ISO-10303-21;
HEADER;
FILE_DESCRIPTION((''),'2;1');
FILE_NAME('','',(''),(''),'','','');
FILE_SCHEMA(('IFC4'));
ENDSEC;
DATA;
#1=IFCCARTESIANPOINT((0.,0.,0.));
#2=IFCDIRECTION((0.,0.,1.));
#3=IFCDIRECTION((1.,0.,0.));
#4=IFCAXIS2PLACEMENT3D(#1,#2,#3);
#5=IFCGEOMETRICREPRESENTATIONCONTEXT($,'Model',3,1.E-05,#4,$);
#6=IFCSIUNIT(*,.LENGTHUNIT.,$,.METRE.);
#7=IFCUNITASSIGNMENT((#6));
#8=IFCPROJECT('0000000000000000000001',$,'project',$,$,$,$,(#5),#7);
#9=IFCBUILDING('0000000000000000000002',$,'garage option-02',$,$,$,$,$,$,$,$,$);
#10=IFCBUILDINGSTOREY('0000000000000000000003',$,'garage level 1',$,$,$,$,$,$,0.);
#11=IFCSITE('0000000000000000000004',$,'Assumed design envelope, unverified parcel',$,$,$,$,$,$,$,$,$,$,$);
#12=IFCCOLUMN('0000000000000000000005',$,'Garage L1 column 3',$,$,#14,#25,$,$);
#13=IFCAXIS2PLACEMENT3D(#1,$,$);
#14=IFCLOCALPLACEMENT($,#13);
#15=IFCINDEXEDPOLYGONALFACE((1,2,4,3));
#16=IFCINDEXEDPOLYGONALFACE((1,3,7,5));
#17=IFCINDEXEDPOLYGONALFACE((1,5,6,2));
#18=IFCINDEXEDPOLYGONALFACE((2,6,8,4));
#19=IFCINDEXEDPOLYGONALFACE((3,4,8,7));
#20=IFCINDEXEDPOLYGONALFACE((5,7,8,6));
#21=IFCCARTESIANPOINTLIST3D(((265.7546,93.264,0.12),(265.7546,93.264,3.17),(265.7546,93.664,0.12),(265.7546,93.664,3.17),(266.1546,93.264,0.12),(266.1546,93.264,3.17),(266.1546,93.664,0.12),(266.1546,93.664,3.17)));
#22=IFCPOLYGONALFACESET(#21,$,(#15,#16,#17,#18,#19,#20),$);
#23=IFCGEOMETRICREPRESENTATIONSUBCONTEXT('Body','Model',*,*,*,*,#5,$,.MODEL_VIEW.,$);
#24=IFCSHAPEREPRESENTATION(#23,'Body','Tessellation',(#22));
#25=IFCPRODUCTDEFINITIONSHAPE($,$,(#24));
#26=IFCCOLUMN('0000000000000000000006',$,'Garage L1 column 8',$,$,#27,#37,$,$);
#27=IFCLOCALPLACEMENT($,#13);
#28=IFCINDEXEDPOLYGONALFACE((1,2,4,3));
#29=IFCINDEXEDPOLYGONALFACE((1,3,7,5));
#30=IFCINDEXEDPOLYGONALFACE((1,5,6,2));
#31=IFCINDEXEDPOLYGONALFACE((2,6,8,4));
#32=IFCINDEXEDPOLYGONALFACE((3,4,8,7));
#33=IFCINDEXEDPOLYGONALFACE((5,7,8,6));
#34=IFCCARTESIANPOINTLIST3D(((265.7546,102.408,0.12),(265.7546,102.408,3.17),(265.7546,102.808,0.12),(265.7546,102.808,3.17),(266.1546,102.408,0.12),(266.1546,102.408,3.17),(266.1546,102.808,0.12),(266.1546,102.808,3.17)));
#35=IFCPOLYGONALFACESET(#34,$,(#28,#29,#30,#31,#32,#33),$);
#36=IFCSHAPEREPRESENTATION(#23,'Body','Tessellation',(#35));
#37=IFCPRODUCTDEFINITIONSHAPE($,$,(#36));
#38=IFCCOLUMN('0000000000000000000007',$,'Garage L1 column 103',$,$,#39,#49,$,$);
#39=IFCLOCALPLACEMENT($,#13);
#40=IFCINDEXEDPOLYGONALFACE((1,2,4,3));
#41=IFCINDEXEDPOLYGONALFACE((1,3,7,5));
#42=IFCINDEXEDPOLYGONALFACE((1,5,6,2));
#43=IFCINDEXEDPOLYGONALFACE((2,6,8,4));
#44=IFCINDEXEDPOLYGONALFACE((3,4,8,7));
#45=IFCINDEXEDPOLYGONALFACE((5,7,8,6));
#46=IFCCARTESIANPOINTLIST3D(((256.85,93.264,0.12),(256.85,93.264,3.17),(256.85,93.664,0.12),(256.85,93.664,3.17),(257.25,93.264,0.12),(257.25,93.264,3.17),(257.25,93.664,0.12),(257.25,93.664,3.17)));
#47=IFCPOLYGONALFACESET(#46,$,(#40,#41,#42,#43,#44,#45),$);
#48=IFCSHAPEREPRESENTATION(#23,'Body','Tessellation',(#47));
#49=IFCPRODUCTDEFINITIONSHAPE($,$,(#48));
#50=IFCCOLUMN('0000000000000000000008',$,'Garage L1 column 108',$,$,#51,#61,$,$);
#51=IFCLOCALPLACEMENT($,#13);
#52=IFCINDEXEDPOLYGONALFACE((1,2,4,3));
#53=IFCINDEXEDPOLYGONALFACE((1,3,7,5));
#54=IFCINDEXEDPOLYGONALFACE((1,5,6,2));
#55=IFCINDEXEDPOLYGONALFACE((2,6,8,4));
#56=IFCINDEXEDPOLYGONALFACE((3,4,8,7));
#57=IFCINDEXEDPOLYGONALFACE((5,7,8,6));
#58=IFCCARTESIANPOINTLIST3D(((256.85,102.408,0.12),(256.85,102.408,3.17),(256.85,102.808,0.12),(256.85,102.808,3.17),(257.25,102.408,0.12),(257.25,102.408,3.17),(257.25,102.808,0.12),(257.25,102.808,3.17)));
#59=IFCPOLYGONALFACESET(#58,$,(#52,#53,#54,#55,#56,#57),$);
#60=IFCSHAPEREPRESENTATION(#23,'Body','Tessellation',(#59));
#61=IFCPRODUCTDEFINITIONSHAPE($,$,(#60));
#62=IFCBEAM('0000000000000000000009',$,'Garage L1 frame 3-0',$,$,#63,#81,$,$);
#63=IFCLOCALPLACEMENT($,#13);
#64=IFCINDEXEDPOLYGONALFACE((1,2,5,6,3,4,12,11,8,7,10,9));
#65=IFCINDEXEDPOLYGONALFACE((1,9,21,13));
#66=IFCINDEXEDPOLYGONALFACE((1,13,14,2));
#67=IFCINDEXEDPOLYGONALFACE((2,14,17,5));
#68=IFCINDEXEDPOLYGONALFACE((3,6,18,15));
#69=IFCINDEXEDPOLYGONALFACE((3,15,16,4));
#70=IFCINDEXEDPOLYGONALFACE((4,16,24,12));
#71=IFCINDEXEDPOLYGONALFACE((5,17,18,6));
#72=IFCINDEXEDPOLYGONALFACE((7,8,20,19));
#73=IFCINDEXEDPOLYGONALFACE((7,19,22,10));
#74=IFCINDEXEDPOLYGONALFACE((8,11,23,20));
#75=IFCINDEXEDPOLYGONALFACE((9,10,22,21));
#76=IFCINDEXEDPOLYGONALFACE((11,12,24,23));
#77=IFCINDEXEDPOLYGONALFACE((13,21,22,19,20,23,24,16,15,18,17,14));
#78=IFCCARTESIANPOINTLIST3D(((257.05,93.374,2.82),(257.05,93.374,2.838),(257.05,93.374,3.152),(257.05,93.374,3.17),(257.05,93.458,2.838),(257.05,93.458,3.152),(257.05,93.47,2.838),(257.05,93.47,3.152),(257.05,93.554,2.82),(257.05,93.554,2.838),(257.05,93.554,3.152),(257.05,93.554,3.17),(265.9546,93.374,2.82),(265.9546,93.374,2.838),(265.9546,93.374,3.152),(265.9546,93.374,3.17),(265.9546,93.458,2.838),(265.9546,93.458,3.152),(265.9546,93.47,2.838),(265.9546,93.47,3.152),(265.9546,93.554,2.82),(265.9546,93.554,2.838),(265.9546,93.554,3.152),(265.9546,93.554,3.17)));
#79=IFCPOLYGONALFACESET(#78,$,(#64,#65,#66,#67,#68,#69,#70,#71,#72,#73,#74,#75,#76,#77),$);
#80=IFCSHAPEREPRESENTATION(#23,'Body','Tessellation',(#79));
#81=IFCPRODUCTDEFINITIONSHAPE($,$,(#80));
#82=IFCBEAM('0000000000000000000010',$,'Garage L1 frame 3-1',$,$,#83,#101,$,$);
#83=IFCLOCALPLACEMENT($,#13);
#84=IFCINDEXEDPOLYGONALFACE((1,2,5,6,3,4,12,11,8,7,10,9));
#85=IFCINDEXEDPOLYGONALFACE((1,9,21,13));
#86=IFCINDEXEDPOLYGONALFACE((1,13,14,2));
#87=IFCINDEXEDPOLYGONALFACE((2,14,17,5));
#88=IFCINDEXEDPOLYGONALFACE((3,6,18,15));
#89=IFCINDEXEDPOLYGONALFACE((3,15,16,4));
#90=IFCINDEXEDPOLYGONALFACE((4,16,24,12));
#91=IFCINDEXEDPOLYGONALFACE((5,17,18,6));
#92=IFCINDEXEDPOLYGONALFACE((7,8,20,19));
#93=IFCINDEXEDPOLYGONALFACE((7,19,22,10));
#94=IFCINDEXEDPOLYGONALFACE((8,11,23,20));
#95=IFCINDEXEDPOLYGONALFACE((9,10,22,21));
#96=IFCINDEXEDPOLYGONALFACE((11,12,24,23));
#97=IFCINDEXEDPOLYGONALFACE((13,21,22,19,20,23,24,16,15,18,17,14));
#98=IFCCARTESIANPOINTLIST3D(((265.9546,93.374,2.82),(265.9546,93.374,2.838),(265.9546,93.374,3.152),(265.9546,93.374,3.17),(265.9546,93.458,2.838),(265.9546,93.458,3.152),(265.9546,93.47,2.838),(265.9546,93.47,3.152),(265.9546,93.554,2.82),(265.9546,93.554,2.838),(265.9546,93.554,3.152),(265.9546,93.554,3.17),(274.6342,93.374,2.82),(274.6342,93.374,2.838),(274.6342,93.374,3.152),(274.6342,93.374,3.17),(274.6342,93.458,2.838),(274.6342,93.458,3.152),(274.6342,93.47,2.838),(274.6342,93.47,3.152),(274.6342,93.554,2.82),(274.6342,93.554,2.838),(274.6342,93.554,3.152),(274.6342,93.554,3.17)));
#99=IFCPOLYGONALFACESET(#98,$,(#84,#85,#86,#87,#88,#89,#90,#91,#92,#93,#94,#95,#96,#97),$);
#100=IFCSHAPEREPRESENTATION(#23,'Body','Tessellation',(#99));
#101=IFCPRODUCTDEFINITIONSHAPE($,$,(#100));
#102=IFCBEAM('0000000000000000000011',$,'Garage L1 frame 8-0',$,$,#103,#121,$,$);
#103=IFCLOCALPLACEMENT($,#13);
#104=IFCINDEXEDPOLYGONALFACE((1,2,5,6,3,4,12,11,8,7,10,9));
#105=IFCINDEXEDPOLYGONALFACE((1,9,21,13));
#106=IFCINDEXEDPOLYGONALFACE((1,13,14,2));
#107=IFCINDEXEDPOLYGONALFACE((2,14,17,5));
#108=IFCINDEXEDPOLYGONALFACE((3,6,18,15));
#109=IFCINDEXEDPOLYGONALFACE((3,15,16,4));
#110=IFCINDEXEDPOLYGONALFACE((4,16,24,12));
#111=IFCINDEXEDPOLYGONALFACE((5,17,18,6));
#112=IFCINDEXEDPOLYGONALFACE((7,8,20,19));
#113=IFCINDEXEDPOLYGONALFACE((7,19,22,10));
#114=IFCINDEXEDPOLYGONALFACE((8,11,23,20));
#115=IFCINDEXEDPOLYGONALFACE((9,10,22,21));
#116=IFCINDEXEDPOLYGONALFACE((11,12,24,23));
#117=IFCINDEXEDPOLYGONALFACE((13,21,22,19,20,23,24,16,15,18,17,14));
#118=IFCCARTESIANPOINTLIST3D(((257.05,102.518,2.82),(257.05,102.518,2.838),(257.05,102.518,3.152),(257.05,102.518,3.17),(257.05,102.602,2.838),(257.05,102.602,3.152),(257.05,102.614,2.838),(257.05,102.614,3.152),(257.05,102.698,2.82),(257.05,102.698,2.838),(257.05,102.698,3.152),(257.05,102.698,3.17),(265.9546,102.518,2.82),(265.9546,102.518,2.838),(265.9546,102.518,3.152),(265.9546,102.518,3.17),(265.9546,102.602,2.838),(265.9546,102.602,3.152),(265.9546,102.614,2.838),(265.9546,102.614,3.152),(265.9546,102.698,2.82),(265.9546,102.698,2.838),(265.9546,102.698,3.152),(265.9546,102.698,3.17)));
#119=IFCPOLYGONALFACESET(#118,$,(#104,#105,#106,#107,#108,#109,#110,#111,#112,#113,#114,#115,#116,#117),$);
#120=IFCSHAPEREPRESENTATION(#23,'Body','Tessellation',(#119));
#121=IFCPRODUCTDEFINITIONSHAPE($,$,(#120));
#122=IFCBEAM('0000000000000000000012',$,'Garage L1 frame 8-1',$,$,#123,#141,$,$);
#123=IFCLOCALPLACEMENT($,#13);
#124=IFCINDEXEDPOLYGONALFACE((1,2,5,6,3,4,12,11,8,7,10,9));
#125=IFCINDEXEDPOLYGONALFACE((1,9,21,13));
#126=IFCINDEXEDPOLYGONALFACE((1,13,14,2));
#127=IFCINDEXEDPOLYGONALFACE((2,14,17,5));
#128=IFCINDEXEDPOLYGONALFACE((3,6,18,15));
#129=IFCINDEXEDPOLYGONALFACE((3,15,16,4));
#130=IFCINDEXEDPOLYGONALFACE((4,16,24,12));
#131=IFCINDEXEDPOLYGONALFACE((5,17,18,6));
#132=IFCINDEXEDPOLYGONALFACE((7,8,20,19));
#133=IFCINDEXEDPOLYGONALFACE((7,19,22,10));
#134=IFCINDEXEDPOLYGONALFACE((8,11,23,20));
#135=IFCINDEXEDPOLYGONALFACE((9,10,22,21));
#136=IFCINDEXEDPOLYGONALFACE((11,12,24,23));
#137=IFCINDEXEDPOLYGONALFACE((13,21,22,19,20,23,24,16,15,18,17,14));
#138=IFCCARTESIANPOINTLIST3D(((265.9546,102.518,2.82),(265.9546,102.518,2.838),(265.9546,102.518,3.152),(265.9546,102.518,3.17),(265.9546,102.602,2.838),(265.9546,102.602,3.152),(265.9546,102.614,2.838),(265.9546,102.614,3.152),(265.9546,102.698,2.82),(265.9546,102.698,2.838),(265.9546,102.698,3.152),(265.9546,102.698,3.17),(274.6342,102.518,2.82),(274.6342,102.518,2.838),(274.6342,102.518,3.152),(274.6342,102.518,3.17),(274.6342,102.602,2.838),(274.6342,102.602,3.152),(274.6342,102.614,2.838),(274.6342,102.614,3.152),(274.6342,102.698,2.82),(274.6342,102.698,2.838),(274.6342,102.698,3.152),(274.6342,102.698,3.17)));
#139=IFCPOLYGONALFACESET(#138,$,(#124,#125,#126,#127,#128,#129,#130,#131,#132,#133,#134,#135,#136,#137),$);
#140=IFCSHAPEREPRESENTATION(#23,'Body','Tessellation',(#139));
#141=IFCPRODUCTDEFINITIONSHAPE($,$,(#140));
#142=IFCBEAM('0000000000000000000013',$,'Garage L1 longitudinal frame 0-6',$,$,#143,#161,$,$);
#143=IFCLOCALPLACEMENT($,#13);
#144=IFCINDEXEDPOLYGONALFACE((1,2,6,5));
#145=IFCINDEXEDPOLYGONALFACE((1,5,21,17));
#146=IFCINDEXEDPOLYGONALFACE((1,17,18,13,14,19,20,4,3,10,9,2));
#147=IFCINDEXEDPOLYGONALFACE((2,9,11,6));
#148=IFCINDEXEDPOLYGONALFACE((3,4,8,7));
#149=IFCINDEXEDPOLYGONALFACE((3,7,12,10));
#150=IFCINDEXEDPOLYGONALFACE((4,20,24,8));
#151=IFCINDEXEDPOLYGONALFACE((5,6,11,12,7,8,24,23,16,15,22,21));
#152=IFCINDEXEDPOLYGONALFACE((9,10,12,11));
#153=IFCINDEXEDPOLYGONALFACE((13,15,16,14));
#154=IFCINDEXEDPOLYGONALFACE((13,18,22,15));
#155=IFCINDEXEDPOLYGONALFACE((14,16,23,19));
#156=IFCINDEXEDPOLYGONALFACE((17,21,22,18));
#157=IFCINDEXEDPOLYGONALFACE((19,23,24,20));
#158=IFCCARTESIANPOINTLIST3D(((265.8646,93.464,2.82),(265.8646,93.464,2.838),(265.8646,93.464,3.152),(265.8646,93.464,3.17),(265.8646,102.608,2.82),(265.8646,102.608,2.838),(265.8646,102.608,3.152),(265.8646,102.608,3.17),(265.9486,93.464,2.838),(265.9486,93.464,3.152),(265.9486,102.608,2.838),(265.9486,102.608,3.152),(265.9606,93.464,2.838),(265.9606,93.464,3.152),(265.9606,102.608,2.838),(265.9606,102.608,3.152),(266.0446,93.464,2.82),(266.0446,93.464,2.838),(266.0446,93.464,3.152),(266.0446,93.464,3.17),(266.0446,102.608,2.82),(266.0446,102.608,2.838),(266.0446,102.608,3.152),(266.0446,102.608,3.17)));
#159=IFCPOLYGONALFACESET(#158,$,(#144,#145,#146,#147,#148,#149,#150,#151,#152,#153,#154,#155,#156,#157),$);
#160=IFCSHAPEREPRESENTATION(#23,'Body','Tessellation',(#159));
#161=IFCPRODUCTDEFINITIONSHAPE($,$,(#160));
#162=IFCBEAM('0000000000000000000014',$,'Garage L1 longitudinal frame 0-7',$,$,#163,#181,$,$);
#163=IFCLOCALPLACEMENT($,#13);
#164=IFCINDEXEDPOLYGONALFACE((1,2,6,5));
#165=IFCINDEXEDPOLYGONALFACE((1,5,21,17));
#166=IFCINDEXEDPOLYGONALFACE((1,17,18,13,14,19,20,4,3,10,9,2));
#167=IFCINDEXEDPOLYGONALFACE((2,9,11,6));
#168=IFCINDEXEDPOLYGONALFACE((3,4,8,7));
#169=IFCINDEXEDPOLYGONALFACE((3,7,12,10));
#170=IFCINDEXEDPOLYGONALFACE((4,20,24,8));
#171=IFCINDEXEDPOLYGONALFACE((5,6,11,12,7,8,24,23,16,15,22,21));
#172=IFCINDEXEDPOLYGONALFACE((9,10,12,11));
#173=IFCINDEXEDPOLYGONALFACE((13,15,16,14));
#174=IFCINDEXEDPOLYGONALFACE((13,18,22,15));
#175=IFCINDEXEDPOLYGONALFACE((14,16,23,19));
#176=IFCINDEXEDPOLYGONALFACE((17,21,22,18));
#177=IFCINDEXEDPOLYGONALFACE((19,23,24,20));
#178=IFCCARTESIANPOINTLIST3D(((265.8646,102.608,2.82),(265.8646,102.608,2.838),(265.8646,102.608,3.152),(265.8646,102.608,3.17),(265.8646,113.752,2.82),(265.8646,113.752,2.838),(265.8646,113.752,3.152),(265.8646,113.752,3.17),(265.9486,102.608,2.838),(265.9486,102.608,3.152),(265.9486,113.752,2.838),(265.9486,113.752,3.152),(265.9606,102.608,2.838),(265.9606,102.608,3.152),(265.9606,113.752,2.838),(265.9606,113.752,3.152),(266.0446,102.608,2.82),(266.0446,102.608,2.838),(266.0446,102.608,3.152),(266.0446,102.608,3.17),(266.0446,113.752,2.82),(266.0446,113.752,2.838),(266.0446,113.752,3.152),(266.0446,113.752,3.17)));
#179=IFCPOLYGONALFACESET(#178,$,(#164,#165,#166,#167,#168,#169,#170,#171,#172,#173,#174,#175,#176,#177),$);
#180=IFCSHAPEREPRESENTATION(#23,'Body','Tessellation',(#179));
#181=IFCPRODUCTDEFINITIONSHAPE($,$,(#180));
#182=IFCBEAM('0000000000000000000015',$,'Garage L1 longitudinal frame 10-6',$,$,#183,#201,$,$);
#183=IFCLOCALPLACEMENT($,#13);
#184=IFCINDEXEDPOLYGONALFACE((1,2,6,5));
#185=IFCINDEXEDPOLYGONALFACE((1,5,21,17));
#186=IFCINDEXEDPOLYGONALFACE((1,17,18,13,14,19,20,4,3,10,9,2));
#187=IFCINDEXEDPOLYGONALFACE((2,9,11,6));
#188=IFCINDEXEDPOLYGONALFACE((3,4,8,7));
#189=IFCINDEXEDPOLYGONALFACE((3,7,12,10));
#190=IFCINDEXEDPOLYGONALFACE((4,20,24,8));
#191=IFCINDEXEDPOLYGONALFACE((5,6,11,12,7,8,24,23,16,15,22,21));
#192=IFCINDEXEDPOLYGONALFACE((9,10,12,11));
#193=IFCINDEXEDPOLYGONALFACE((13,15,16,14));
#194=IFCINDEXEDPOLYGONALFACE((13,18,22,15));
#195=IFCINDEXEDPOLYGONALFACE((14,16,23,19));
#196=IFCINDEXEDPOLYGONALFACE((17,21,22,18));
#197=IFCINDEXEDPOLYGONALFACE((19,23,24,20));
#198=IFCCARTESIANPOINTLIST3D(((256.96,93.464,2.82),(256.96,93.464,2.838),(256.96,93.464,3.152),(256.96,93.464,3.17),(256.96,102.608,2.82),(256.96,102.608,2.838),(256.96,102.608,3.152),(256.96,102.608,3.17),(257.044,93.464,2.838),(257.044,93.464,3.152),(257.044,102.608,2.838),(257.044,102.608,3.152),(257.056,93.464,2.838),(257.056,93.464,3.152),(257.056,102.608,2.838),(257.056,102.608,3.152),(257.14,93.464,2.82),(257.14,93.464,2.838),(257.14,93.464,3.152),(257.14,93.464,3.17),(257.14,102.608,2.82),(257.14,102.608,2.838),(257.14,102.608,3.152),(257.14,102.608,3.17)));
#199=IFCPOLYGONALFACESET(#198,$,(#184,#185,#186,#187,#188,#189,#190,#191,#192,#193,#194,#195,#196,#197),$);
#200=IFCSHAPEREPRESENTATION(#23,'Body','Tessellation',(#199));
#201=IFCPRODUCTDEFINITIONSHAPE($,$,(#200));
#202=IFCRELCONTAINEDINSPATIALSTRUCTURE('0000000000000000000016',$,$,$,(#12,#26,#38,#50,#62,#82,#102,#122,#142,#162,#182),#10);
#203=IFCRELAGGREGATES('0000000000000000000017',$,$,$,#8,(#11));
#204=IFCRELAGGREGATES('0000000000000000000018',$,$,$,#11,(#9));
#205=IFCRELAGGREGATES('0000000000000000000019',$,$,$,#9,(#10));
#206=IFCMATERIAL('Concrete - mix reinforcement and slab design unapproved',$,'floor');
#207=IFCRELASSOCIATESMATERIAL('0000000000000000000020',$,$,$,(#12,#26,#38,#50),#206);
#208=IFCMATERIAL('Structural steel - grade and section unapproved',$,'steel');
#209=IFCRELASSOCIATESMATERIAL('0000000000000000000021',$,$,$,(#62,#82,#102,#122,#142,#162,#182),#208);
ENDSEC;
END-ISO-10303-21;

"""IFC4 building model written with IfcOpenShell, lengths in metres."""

from ifc_helpers import new_model, si_unit, frame, origin_with_axes, place, context, subcontext, project, spatial, rectangle, i_section, extrude, material, element, save


model = new_model("IFC4")

# Units and contexts
model_context = context("Model", 3, precision=1e-05, world=origin_with_axes())
body_context = subcontext(model_context, "Body", "Model", "MODEL_VIEW")
ifc_project = project(units=[si_unit("LENGTHUNIT", "METRE")], contexts=[model_context])

# Site, building, storey
site = spatial("IfcSite", under=ifc_project, Name="Assumed design envelope, unverified parcel")
building = spatial("IfcBuilding", under=site, Name="garage option-02")
storey = spatial("IfcBuildingStorey", under=building, Name="garage level 1", Elevation=0.0)

# Columns
ifc_material_1 = material(Name="Concrete - mix reinforcement and slab design unapproved", Category="floor")
for number, where, z_axis, x_axis, name in (
    (1, (265.9546, 93.464, 0.12), (0.0, 0.0, 1.0), (1.0, 0.0, 0.0), "Garage L1 column 3"),
    (2, (265.9546, 102.608, 0.12), (0.0, 0.0, 1.0), (1.0, 0.0, 0.0), "Garage L1 column 8"),
    (3, (257.05, 93.464, 0.12), (0.0, 0.0, 1.0), (1.0, 0.0, 0.0), "Garage L1 column 103"),
    (4, (257.05, 102.608, 0.12), (0.0, 0.0, 1.0), (1.0, 0.0, 0.0), "Garage L1 column 108"),
):
    element("IfcColumn", number, at=place(None, frame(where, z_axis=z_axis, x_axis=x_axis)), inside=storey, material=ifc_material_1, Name=name, context=body_context, shape_type="SweptSolid", body=[
        extrude(rectangle(XDim=0.4, YDim=0.4), origin_with_axes(), (0.0, 0.0, 1.0), 3.05),
    ])

# Beams
ifc_material_2 = material(Name="Structural steel - grade and section unapproved", Category="steel")
beam_1_placement = place(None, frame((257.05, 93.464, 2.995), z_axis=(1.0, 0.0, 0.0), x_axis=(0.0, 1.0, 0.0)))
element("IfcBeam", 5, at=beam_1_placement, inside=storey, material=ifc_material_2, Name="Garage L1 frame 3-0", context=body_context, shape_type="SweptSolid", body=[
    extrude(i_section(OverallWidth=0.18, OverallDepth=0.35, WebThickness=0.012, FlangeThickness=0.018, FilletRadius=0.0), origin_with_axes(), (0.0, 0.0, 1.0), 8.9046),
])
beam_2_placement = place(None, frame((265.9546, 93.464, 2.995), z_axis=(1.0, 0.0, 0.0), x_axis=(0.0, 1.0, 0.0)))
element("IfcBeam", 6, at=beam_2_placement, inside=storey, material=ifc_material_2, Name="Garage L1 frame 3-1", context=body_context, shape_type="SweptSolid", body=[
    extrude(i_section(OverallWidth=0.18, OverallDepth=0.35, WebThickness=0.012, FlangeThickness=0.018, FilletRadius=0.0), origin_with_axes(), (0.0, 0.0, 1.0), 8.6796),
])
beam_3_placement = place(None, frame((257.05, 102.608, 2.995), z_axis=(1.0, 0.0, 0.0), x_axis=(0.0, 1.0, 0.0)))
element("IfcBeam", 7, at=beam_3_placement, inside=storey, material=ifc_material_2, Name="Garage L1 frame 8-0", context=body_context, shape_type="SweptSolid", body=[
    extrude(i_section(OverallWidth=0.18, OverallDepth=0.35, WebThickness=0.012, FlangeThickness=0.018, FilletRadius=0.0), origin_with_axes(), (0.0, 0.0, 1.0), 8.9046),
])
beam_4_placement = place(None, frame((265.9546, 102.608, 2.995), z_axis=(1.0, 0.0, 0.0), x_axis=(0.0, 1.0, 0.0)))
element("IfcBeam", 8, at=beam_4_placement, inside=storey, material=ifc_material_2, Name="Garage L1 frame 8-1", context=body_context, shape_type="SweptSolid", body=[
    extrude(i_section(OverallWidth=0.18, OverallDepth=0.35, WebThickness=0.012, FlangeThickness=0.018, FilletRadius=0.0), origin_with_axes(), (0.0, 0.0, 1.0), 8.6796),
])
beam_5_placement = place(None, frame((265.9546, 93.464, 2.995), z_axis=(0.0, 1.0, 0.0), x_axis=(-1.0, 0.0, 0.0)))
element("IfcBeam", 9, at=beam_5_placement, inside=storey, material=ifc_material_2, Name="Garage L1 longitudinal frame 0-6", context=body_context, shape_type="SweptSolid", body=[
    extrude(i_section(OverallWidth=0.18, OverallDepth=0.35, WebThickness=0.012, FlangeThickness=0.018, FilletRadius=0.0), origin_with_axes(), (0.0, 0.0, 1.0), 9.144),
])
beam_6_placement = place(None, frame((265.9546, 102.608, 2.995), z_axis=(0.0, 1.0, 0.0), x_axis=(-1.0, 0.0, 0.0)))
element("IfcBeam", 10, at=beam_6_placement, inside=storey, material=ifc_material_2, Name="Garage L1 longitudinal frame 0-7", context=body_context, shape_type="SweptSolid", body=[
    extrude(i_section(OverallWidth=0.18, OverallDepth=0.35, WebThickness=0.012, FlangeThickness=0.018, FilletRadius=0.0), origin_with_axes(), (0.0, 0.0, 1.0), 11.144),
])
beam_7_placement = place(None, frame((257.05, 93.464, 2.995), z_axis=(0.0, 1.0, 0.0), x_axis=(-1.0, 0.0, 0.0)))
element("IfcBeam", 11, at=beam_7_placement, inside=storey, material=ifc_material_2, Name="Garage L1 longitudinal frame 10-6", context=body_context, shape_type="SweptSolid", body=[
    extrude(i_section(OverallWidth=0.18, OverallDepth=0.35, WebThickness=0.012, FlangeThickness=0.018, FilletRadius=0.0), origin_with_axes(), (0.0, 0.0, 1.0), 9.144),
])

save(model, "model.ifc")
